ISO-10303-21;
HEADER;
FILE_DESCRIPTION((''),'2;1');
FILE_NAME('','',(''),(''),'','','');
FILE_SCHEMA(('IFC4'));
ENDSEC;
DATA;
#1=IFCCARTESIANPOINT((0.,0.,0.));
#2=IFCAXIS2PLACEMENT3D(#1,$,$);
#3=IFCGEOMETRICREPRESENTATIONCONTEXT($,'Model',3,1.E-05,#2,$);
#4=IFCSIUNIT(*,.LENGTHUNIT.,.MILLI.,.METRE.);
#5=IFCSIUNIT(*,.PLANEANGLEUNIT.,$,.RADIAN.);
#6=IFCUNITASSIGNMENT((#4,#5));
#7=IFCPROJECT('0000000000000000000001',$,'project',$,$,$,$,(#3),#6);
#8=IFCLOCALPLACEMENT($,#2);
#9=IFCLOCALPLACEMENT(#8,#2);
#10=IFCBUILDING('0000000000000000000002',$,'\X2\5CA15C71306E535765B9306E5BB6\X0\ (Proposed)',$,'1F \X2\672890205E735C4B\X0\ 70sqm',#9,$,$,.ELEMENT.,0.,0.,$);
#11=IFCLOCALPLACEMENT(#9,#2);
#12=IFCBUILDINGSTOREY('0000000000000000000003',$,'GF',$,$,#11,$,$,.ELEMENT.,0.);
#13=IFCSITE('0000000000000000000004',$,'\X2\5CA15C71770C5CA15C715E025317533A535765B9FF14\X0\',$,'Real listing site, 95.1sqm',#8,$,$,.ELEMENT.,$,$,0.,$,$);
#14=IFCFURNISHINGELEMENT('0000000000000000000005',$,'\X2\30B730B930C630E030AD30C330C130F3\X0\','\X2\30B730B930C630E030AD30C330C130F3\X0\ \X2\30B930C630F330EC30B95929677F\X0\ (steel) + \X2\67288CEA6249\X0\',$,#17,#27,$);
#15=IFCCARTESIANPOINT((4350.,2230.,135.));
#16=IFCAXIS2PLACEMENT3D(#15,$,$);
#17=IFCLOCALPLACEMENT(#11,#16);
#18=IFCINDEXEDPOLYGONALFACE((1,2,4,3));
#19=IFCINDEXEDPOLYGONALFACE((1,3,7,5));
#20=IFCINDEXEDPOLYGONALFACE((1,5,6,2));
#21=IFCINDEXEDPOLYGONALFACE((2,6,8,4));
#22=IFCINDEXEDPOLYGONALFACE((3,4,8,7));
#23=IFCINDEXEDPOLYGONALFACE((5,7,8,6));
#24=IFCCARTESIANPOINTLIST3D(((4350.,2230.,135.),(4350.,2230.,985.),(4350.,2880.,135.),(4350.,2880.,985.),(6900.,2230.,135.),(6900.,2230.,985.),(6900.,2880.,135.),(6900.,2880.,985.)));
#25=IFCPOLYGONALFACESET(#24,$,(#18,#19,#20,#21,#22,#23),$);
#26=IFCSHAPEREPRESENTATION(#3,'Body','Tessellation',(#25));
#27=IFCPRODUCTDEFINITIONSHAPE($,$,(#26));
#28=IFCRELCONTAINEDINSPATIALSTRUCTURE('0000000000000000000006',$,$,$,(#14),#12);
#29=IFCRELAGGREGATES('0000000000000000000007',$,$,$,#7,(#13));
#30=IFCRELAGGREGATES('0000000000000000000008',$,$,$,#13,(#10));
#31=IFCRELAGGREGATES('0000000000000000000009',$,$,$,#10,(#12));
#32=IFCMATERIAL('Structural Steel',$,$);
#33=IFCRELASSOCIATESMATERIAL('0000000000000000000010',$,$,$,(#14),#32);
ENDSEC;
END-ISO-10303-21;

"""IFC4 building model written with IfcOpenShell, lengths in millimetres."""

from ifc_helpers import new_model, si_unit, frame, frame_2d, origin, place, context, project, spatial, rectangle, extrude, material, element, save


model = new_model("IFC4")

# Units and contexts
model_context = context("Model", 3, precision=1e-05, world=origin())
ifc_project = project(units=[si_unit("LENGTHUNIT", "METRE", prefix="MILLI"), si_unit("PLANEANGLEUNIT", "RADIAN")], contexts=[model_context])

# Site, building, storey
site_placement = place(None, origin())
site = spatial("IfcSite", under=ifc_project, at=site_placement, Name="岡山県岡山市北区南方４", ObjectType="Real listing site, 95.1sqm", CompositionType="ELEMENT", RefElevation=0.0)
building_placement = place(site_placement, origin())
building = spatial("IfcBuilding", under=site, at=building_placement, Name="岡山の南方の家 (Proposed)", ObjectType="1F 木造平屋 70sqm", CompositionType="ELEMENT", ElevationOfRefHeight=0.0, ElevationOfTerrain=0.0)
storey_placement = place(building_placement, origin())
storey = spatial("IfcBuildingStorey", under=building, at=storey_placement, Name="GF", CompositionType="ELEMENT", Elevation=0.0)

# Furnishing element
ifc_material_1 = material(Name="Structural Steel")
furnishing_placement = place(storey_placement, frame((4350.0, 2230.0, 135.0)))
element("IfcFurnishingElement", 1, at=furnishing_placement, inside=storey, material=ifc_material_1, Name="システムキッチン", Description="システムキッチン ステンレス天板 (steel) + 木質扉", context=model_context, shape_type="SweptSolid", body=[
    extrude(rectangle(XDim=2550.0, YDim=650.0, at=frame_2d((1275.0, 325.0))), frame((4350.0, 2230.0, 135.0)), (0.0, 0.0, 1.0), 850.0),
])

save(model, "model.ifc")
